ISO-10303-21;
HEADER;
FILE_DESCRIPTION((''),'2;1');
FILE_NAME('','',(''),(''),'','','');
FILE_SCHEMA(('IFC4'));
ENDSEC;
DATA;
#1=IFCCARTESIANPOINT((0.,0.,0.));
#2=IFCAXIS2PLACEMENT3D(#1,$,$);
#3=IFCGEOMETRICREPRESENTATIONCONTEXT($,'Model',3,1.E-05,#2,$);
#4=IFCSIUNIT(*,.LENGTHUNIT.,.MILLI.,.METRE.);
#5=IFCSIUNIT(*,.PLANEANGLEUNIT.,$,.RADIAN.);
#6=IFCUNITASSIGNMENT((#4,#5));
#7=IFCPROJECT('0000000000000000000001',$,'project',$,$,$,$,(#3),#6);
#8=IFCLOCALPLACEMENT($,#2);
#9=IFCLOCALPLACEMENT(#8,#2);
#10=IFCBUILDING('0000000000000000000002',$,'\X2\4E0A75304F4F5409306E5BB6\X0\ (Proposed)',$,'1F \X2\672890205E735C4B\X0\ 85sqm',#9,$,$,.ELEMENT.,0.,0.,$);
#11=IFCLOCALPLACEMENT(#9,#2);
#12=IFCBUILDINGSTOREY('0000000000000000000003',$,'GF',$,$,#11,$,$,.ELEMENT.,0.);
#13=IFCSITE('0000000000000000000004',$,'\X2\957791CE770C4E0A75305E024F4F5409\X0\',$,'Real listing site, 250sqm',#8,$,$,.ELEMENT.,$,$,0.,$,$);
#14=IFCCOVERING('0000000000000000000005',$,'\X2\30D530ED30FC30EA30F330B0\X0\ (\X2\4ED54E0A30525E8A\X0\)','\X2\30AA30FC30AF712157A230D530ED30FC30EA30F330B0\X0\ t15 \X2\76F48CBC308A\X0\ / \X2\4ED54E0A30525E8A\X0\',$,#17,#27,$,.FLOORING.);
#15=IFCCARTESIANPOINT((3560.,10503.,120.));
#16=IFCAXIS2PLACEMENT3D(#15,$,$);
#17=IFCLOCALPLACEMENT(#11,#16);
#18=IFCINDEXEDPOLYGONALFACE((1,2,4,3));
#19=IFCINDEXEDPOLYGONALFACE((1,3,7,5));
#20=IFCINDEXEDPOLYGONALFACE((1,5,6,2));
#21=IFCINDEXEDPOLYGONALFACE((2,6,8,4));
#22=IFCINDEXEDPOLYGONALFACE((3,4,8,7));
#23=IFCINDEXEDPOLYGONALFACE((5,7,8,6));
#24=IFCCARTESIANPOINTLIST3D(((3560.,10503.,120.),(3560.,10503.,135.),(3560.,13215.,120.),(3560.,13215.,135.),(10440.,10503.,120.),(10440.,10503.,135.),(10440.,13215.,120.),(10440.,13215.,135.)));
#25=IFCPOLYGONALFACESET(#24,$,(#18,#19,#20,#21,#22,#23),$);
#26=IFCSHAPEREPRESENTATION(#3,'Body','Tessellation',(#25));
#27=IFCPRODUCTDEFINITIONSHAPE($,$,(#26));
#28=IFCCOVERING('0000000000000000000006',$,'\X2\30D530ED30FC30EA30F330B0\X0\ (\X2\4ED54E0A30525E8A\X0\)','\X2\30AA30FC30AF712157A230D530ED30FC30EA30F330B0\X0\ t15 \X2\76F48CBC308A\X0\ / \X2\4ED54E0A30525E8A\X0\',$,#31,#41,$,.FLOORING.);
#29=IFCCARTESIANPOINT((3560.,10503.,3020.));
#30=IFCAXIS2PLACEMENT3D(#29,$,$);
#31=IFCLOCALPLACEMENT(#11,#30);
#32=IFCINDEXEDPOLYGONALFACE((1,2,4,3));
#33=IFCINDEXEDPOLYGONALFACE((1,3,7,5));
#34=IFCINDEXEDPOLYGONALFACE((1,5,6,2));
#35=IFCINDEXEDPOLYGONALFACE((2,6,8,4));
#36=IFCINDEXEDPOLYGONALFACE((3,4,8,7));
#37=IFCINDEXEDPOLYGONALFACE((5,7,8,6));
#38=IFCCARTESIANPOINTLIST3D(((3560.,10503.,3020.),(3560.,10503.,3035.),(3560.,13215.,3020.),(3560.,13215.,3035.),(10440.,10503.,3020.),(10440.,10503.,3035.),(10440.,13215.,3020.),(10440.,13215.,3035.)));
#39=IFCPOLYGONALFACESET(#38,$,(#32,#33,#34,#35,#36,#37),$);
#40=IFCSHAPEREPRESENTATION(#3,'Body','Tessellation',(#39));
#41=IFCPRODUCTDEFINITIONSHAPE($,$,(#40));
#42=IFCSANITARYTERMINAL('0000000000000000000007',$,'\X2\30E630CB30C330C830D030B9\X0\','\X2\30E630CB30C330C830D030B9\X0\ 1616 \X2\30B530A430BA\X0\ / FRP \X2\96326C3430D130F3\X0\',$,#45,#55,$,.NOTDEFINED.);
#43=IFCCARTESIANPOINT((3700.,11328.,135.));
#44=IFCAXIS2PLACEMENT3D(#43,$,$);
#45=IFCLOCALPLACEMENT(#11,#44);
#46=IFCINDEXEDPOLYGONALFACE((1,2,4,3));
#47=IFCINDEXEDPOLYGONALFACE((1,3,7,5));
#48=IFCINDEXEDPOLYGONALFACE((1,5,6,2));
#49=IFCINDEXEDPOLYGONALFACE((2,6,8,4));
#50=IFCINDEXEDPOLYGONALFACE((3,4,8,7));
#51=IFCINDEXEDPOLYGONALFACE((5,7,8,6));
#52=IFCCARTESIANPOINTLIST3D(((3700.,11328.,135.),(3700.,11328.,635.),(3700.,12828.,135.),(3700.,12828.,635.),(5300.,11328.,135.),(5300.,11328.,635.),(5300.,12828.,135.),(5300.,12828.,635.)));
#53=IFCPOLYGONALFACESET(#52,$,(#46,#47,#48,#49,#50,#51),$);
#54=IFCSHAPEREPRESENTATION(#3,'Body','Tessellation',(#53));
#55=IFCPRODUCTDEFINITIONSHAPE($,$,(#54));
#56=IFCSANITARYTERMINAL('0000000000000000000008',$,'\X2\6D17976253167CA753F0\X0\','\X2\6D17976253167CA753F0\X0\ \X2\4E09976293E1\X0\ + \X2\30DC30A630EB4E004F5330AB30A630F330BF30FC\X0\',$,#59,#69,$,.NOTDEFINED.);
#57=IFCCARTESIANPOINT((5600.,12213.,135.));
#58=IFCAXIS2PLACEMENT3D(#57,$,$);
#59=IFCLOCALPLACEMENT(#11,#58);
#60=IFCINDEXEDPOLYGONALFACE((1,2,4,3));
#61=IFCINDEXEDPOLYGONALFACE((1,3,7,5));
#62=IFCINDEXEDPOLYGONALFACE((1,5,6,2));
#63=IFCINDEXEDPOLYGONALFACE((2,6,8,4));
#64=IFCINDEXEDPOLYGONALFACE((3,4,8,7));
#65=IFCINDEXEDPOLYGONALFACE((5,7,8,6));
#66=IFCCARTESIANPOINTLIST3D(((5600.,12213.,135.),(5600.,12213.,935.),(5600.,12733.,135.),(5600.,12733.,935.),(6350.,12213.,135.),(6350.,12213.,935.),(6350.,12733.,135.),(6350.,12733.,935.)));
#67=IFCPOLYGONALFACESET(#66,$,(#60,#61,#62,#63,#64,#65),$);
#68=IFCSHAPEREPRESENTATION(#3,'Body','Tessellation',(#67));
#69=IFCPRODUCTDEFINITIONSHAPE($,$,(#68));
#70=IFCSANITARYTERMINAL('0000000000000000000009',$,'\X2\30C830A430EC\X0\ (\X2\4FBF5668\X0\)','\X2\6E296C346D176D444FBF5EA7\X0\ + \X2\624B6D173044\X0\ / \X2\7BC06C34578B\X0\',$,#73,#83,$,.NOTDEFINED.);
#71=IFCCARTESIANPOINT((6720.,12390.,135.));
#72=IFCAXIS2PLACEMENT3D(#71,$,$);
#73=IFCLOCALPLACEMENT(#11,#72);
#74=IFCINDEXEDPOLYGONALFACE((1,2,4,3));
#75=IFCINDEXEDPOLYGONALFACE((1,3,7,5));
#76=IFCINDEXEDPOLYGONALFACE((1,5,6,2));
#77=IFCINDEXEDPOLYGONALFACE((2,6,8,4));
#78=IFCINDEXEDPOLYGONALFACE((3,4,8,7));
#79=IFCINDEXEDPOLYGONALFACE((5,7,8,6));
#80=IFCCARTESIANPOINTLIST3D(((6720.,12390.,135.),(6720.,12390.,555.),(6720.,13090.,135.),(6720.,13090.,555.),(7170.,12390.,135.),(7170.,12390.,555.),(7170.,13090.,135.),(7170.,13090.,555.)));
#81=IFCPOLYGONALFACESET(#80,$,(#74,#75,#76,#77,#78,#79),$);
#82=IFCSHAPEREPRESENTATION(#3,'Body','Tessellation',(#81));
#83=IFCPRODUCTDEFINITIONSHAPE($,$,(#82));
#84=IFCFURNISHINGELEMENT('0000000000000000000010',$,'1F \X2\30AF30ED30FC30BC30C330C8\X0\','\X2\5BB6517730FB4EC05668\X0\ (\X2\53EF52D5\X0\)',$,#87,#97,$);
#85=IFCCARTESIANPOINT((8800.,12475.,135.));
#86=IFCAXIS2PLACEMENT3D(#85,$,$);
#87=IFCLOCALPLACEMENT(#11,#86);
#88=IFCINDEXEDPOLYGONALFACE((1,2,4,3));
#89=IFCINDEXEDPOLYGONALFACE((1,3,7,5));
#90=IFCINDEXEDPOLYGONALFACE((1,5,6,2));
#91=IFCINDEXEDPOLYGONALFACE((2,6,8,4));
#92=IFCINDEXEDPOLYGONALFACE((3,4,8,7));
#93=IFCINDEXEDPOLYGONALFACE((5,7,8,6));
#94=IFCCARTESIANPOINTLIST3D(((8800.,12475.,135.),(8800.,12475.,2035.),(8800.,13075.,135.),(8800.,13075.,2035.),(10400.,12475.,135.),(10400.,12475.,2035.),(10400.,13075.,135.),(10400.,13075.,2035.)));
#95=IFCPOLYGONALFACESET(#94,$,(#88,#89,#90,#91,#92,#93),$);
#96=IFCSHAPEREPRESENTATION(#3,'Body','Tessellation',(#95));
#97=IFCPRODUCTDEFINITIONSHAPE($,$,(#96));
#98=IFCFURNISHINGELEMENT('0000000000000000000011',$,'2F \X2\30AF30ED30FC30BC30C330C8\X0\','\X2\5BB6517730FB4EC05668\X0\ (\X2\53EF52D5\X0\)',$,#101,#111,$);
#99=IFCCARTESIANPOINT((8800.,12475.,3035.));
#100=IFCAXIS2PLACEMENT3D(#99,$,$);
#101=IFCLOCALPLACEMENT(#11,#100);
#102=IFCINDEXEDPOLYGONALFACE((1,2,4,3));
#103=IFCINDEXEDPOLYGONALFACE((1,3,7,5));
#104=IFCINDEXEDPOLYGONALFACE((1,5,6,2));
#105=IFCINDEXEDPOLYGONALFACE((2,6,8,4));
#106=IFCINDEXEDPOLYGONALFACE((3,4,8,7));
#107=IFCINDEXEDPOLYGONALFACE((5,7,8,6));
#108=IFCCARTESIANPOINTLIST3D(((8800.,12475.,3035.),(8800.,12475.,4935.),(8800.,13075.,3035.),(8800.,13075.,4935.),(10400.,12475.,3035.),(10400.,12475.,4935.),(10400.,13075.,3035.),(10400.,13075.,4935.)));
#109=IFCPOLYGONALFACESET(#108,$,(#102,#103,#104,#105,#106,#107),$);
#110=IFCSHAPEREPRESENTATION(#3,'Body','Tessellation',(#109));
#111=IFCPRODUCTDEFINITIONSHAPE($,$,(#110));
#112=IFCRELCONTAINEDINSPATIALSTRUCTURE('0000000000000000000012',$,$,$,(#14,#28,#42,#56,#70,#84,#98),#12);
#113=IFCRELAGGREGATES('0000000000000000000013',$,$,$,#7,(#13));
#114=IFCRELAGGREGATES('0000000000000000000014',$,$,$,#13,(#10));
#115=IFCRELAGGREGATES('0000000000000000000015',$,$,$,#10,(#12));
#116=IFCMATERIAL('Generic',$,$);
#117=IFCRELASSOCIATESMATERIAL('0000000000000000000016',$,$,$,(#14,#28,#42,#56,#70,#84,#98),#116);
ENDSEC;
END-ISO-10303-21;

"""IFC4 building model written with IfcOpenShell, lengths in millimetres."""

from ifc_helpers import new_model, si_unit, frame, frame_2d, origin, place, context, project, spatial, rectangle, extrude, material, element, save


model = new_model("IFC4")

# Units and contexts
model_context = context("Model", 3, precision=1e-05, world=origin())
ifc_project = project(units=[si_unit("LENGTHUNIT", "METRE", prefix="MILLI"), si_unit("PLANEANGLEUNIT", "RADIAN")], contexts=[model_context])

# Site, building, storey
site_placement = place(None, origin())
site = spatial("IfcSite", under=ifc_project, at=site_placement, Name="長野県上田市住吉", ObjectType="Real listing site, 250sqm", CompositionType="ELEMENT", RefElevation=0.0)
building_placement = place(site_placement, origin())
building = spatial("IfcBuilding", under=site, at=building_placement, Name="上田住吉の家 (Proposed)", ObjectType="1F 木造平屋 85sqm", CompositionType="ELEMENT", ElevationOfRefHeight=0.0, ElevationOfTerrain=0.0)
storey_placement = place(building_placement, origin())
storey = spatial("IfcBuildingStorey", under=building, at=storey_placement, Name="GF", CompositionType="ELEMENT", Elevation=0.0)

# Coverings
ifc_material_1 = material(Name="Generic")
covering_1_placement = place(storey_placement, frame((3560.0, 10503.0, 120.0)))
element("IfcCovering", 1, at=covering_1_placement, inside=storey, material=ifc_material_1, Name="フローリング (仕上げ床)", Description="オーク無垢フローリング t15 直貼り / 仕上げ床", PredefinedType="FLOORING", context=model_context, shape_type="SweptSolid", body=[
    extrude(rectangle(XDim=6880.0, YDim=2712.0, at=frame_2d((3440.0, 1356.0))), frame((3560.0, 10503.0, 120.0)), (0.0, 0.0, 1.0), 15.0),
])
covering_2_placement = place(storey_placement, frame((3560.0, 10503.0, 3020.0)))
element("IfcCovering", 2, at=covering_2_placement, inside=storey, material=ifc_material_1, Name="フローリング (仕上げ床)", Description="オーク無垢フローリング t15 直貼り / 仕上げ床", PredefinedType="FLOORING", context=model_context, shape_type="SweptSolid", body=[
    extrude(rectangle(XDim=6880.0, YDim=2712.0, at=frame_2d((3440.0, 1356.0))), frame((3560.0, 10503.0, 3020.0)), (0.0, 0.0, 1.0), 15.0),
])

# Sanitary terminals
sanitary_terminal_1_placement = place(storey_placement, frame((3700.0, 11328.0, 135.0)))
element("IfcSanitaryTerminal", 3, at=sanitary_terminal_1_placement, inside=storey, material=ifc_material_1, Name="ユニットバス", Description="ユニットバス 1616 サイズ / FRP 防水パン", PredefinedType="NOTDEFINED", context=model_context, shape_type="SweptSolid", body=[
    extrude(rectangle(XDim=1600.0, YDim=1500.0, at=frame_2d((800.0, 750.0))), frame((3700.0, 11328.0, 135.0)), (0.0, 0.0, 1.0), 500.0),
])
sanitary_terminal_2_placement = place(storey_placement, frame((5600.0, 12213.0, 135.0)))
element("IfcSanitaryTerminal", 4, at=sanitary_terminal_2_placement, inside=storey, material=ifc_material_1, Name="洗面化粧台", Description="洗面化粧台 三面鏡 + ボウル一体カウンター", PredefinedType="NOTDEFINED", context=model_context, shape_type="SweptSolid", body=[
    extrude(rectangle(XDim=750.0, YDim=520.0, at=frame_2d((375.0, 260.0))), frame((5600.0, 12213.0, 135.0)), (0.0, 0.0, 1.0), 800.0),
])
sanitary_terminal_3_placement = place(storey_placement, frame((6720.0, 12390.0, 135.0)))
element("IfcSanitaryTerminal", 5, at=sanitary_terminal_3_placement, inside=storey, material=ifc_material_1, Name="トイレ (便器)", Description="温水洗浄便座 + 手洗い / 節水型", PredefinedType="NOTDEFINED", context=model_context, shape_type="SweptSolid", body=[
    extrude(rectangle(XDim=450.0, YDim=700.0, at=frame_2d((225.0, 350.0))), frame((6720.0, 12390.0, 135.0)), (0.0, 0.0, 1.0), 420.0),
])

# Furnishing elements
furnishing_1_placement = place(storey_placement, frame((8800.0, 12475.0, 135.0)))
element("IfcFurnishingElement", 6, at=furnishing_1_placement, inside=storey, material=ifc_material_1, Name="1F クローゼット", Description="家具・什器 (可動)", context=model_context, shape_type="SweptSolid", body=[
    extrude(rectangle(XDim=1600.0, YDim=600.0, at=frame_2d((800.0, 300.0))), frame((8800.0, 12475.0, 135.0)), (0.0, 0.0, 1.0), 1900.0),
])
furnishing_2_placement = place(storey_placement, frame((8800.0, 12475.0, 3035.0)))
element("IfcFurnishingElement", 7, at=furnishing_2_placement, inside=storey, material=ifc_material_1, Name="2F クローゼット", Description="家具・什器 (可動)", context=model_context, shape_type="SweptSolid", body=[
    extrude(rectangle(XDim=1600.0, YDim=600.0, at=frame_2d((800.0, 300.0))), frame((8800.0, 12475.0, 3035.0)), (0.0, 0.0, 1.0), 1900.0),
])

save(model, "model.ifc")
